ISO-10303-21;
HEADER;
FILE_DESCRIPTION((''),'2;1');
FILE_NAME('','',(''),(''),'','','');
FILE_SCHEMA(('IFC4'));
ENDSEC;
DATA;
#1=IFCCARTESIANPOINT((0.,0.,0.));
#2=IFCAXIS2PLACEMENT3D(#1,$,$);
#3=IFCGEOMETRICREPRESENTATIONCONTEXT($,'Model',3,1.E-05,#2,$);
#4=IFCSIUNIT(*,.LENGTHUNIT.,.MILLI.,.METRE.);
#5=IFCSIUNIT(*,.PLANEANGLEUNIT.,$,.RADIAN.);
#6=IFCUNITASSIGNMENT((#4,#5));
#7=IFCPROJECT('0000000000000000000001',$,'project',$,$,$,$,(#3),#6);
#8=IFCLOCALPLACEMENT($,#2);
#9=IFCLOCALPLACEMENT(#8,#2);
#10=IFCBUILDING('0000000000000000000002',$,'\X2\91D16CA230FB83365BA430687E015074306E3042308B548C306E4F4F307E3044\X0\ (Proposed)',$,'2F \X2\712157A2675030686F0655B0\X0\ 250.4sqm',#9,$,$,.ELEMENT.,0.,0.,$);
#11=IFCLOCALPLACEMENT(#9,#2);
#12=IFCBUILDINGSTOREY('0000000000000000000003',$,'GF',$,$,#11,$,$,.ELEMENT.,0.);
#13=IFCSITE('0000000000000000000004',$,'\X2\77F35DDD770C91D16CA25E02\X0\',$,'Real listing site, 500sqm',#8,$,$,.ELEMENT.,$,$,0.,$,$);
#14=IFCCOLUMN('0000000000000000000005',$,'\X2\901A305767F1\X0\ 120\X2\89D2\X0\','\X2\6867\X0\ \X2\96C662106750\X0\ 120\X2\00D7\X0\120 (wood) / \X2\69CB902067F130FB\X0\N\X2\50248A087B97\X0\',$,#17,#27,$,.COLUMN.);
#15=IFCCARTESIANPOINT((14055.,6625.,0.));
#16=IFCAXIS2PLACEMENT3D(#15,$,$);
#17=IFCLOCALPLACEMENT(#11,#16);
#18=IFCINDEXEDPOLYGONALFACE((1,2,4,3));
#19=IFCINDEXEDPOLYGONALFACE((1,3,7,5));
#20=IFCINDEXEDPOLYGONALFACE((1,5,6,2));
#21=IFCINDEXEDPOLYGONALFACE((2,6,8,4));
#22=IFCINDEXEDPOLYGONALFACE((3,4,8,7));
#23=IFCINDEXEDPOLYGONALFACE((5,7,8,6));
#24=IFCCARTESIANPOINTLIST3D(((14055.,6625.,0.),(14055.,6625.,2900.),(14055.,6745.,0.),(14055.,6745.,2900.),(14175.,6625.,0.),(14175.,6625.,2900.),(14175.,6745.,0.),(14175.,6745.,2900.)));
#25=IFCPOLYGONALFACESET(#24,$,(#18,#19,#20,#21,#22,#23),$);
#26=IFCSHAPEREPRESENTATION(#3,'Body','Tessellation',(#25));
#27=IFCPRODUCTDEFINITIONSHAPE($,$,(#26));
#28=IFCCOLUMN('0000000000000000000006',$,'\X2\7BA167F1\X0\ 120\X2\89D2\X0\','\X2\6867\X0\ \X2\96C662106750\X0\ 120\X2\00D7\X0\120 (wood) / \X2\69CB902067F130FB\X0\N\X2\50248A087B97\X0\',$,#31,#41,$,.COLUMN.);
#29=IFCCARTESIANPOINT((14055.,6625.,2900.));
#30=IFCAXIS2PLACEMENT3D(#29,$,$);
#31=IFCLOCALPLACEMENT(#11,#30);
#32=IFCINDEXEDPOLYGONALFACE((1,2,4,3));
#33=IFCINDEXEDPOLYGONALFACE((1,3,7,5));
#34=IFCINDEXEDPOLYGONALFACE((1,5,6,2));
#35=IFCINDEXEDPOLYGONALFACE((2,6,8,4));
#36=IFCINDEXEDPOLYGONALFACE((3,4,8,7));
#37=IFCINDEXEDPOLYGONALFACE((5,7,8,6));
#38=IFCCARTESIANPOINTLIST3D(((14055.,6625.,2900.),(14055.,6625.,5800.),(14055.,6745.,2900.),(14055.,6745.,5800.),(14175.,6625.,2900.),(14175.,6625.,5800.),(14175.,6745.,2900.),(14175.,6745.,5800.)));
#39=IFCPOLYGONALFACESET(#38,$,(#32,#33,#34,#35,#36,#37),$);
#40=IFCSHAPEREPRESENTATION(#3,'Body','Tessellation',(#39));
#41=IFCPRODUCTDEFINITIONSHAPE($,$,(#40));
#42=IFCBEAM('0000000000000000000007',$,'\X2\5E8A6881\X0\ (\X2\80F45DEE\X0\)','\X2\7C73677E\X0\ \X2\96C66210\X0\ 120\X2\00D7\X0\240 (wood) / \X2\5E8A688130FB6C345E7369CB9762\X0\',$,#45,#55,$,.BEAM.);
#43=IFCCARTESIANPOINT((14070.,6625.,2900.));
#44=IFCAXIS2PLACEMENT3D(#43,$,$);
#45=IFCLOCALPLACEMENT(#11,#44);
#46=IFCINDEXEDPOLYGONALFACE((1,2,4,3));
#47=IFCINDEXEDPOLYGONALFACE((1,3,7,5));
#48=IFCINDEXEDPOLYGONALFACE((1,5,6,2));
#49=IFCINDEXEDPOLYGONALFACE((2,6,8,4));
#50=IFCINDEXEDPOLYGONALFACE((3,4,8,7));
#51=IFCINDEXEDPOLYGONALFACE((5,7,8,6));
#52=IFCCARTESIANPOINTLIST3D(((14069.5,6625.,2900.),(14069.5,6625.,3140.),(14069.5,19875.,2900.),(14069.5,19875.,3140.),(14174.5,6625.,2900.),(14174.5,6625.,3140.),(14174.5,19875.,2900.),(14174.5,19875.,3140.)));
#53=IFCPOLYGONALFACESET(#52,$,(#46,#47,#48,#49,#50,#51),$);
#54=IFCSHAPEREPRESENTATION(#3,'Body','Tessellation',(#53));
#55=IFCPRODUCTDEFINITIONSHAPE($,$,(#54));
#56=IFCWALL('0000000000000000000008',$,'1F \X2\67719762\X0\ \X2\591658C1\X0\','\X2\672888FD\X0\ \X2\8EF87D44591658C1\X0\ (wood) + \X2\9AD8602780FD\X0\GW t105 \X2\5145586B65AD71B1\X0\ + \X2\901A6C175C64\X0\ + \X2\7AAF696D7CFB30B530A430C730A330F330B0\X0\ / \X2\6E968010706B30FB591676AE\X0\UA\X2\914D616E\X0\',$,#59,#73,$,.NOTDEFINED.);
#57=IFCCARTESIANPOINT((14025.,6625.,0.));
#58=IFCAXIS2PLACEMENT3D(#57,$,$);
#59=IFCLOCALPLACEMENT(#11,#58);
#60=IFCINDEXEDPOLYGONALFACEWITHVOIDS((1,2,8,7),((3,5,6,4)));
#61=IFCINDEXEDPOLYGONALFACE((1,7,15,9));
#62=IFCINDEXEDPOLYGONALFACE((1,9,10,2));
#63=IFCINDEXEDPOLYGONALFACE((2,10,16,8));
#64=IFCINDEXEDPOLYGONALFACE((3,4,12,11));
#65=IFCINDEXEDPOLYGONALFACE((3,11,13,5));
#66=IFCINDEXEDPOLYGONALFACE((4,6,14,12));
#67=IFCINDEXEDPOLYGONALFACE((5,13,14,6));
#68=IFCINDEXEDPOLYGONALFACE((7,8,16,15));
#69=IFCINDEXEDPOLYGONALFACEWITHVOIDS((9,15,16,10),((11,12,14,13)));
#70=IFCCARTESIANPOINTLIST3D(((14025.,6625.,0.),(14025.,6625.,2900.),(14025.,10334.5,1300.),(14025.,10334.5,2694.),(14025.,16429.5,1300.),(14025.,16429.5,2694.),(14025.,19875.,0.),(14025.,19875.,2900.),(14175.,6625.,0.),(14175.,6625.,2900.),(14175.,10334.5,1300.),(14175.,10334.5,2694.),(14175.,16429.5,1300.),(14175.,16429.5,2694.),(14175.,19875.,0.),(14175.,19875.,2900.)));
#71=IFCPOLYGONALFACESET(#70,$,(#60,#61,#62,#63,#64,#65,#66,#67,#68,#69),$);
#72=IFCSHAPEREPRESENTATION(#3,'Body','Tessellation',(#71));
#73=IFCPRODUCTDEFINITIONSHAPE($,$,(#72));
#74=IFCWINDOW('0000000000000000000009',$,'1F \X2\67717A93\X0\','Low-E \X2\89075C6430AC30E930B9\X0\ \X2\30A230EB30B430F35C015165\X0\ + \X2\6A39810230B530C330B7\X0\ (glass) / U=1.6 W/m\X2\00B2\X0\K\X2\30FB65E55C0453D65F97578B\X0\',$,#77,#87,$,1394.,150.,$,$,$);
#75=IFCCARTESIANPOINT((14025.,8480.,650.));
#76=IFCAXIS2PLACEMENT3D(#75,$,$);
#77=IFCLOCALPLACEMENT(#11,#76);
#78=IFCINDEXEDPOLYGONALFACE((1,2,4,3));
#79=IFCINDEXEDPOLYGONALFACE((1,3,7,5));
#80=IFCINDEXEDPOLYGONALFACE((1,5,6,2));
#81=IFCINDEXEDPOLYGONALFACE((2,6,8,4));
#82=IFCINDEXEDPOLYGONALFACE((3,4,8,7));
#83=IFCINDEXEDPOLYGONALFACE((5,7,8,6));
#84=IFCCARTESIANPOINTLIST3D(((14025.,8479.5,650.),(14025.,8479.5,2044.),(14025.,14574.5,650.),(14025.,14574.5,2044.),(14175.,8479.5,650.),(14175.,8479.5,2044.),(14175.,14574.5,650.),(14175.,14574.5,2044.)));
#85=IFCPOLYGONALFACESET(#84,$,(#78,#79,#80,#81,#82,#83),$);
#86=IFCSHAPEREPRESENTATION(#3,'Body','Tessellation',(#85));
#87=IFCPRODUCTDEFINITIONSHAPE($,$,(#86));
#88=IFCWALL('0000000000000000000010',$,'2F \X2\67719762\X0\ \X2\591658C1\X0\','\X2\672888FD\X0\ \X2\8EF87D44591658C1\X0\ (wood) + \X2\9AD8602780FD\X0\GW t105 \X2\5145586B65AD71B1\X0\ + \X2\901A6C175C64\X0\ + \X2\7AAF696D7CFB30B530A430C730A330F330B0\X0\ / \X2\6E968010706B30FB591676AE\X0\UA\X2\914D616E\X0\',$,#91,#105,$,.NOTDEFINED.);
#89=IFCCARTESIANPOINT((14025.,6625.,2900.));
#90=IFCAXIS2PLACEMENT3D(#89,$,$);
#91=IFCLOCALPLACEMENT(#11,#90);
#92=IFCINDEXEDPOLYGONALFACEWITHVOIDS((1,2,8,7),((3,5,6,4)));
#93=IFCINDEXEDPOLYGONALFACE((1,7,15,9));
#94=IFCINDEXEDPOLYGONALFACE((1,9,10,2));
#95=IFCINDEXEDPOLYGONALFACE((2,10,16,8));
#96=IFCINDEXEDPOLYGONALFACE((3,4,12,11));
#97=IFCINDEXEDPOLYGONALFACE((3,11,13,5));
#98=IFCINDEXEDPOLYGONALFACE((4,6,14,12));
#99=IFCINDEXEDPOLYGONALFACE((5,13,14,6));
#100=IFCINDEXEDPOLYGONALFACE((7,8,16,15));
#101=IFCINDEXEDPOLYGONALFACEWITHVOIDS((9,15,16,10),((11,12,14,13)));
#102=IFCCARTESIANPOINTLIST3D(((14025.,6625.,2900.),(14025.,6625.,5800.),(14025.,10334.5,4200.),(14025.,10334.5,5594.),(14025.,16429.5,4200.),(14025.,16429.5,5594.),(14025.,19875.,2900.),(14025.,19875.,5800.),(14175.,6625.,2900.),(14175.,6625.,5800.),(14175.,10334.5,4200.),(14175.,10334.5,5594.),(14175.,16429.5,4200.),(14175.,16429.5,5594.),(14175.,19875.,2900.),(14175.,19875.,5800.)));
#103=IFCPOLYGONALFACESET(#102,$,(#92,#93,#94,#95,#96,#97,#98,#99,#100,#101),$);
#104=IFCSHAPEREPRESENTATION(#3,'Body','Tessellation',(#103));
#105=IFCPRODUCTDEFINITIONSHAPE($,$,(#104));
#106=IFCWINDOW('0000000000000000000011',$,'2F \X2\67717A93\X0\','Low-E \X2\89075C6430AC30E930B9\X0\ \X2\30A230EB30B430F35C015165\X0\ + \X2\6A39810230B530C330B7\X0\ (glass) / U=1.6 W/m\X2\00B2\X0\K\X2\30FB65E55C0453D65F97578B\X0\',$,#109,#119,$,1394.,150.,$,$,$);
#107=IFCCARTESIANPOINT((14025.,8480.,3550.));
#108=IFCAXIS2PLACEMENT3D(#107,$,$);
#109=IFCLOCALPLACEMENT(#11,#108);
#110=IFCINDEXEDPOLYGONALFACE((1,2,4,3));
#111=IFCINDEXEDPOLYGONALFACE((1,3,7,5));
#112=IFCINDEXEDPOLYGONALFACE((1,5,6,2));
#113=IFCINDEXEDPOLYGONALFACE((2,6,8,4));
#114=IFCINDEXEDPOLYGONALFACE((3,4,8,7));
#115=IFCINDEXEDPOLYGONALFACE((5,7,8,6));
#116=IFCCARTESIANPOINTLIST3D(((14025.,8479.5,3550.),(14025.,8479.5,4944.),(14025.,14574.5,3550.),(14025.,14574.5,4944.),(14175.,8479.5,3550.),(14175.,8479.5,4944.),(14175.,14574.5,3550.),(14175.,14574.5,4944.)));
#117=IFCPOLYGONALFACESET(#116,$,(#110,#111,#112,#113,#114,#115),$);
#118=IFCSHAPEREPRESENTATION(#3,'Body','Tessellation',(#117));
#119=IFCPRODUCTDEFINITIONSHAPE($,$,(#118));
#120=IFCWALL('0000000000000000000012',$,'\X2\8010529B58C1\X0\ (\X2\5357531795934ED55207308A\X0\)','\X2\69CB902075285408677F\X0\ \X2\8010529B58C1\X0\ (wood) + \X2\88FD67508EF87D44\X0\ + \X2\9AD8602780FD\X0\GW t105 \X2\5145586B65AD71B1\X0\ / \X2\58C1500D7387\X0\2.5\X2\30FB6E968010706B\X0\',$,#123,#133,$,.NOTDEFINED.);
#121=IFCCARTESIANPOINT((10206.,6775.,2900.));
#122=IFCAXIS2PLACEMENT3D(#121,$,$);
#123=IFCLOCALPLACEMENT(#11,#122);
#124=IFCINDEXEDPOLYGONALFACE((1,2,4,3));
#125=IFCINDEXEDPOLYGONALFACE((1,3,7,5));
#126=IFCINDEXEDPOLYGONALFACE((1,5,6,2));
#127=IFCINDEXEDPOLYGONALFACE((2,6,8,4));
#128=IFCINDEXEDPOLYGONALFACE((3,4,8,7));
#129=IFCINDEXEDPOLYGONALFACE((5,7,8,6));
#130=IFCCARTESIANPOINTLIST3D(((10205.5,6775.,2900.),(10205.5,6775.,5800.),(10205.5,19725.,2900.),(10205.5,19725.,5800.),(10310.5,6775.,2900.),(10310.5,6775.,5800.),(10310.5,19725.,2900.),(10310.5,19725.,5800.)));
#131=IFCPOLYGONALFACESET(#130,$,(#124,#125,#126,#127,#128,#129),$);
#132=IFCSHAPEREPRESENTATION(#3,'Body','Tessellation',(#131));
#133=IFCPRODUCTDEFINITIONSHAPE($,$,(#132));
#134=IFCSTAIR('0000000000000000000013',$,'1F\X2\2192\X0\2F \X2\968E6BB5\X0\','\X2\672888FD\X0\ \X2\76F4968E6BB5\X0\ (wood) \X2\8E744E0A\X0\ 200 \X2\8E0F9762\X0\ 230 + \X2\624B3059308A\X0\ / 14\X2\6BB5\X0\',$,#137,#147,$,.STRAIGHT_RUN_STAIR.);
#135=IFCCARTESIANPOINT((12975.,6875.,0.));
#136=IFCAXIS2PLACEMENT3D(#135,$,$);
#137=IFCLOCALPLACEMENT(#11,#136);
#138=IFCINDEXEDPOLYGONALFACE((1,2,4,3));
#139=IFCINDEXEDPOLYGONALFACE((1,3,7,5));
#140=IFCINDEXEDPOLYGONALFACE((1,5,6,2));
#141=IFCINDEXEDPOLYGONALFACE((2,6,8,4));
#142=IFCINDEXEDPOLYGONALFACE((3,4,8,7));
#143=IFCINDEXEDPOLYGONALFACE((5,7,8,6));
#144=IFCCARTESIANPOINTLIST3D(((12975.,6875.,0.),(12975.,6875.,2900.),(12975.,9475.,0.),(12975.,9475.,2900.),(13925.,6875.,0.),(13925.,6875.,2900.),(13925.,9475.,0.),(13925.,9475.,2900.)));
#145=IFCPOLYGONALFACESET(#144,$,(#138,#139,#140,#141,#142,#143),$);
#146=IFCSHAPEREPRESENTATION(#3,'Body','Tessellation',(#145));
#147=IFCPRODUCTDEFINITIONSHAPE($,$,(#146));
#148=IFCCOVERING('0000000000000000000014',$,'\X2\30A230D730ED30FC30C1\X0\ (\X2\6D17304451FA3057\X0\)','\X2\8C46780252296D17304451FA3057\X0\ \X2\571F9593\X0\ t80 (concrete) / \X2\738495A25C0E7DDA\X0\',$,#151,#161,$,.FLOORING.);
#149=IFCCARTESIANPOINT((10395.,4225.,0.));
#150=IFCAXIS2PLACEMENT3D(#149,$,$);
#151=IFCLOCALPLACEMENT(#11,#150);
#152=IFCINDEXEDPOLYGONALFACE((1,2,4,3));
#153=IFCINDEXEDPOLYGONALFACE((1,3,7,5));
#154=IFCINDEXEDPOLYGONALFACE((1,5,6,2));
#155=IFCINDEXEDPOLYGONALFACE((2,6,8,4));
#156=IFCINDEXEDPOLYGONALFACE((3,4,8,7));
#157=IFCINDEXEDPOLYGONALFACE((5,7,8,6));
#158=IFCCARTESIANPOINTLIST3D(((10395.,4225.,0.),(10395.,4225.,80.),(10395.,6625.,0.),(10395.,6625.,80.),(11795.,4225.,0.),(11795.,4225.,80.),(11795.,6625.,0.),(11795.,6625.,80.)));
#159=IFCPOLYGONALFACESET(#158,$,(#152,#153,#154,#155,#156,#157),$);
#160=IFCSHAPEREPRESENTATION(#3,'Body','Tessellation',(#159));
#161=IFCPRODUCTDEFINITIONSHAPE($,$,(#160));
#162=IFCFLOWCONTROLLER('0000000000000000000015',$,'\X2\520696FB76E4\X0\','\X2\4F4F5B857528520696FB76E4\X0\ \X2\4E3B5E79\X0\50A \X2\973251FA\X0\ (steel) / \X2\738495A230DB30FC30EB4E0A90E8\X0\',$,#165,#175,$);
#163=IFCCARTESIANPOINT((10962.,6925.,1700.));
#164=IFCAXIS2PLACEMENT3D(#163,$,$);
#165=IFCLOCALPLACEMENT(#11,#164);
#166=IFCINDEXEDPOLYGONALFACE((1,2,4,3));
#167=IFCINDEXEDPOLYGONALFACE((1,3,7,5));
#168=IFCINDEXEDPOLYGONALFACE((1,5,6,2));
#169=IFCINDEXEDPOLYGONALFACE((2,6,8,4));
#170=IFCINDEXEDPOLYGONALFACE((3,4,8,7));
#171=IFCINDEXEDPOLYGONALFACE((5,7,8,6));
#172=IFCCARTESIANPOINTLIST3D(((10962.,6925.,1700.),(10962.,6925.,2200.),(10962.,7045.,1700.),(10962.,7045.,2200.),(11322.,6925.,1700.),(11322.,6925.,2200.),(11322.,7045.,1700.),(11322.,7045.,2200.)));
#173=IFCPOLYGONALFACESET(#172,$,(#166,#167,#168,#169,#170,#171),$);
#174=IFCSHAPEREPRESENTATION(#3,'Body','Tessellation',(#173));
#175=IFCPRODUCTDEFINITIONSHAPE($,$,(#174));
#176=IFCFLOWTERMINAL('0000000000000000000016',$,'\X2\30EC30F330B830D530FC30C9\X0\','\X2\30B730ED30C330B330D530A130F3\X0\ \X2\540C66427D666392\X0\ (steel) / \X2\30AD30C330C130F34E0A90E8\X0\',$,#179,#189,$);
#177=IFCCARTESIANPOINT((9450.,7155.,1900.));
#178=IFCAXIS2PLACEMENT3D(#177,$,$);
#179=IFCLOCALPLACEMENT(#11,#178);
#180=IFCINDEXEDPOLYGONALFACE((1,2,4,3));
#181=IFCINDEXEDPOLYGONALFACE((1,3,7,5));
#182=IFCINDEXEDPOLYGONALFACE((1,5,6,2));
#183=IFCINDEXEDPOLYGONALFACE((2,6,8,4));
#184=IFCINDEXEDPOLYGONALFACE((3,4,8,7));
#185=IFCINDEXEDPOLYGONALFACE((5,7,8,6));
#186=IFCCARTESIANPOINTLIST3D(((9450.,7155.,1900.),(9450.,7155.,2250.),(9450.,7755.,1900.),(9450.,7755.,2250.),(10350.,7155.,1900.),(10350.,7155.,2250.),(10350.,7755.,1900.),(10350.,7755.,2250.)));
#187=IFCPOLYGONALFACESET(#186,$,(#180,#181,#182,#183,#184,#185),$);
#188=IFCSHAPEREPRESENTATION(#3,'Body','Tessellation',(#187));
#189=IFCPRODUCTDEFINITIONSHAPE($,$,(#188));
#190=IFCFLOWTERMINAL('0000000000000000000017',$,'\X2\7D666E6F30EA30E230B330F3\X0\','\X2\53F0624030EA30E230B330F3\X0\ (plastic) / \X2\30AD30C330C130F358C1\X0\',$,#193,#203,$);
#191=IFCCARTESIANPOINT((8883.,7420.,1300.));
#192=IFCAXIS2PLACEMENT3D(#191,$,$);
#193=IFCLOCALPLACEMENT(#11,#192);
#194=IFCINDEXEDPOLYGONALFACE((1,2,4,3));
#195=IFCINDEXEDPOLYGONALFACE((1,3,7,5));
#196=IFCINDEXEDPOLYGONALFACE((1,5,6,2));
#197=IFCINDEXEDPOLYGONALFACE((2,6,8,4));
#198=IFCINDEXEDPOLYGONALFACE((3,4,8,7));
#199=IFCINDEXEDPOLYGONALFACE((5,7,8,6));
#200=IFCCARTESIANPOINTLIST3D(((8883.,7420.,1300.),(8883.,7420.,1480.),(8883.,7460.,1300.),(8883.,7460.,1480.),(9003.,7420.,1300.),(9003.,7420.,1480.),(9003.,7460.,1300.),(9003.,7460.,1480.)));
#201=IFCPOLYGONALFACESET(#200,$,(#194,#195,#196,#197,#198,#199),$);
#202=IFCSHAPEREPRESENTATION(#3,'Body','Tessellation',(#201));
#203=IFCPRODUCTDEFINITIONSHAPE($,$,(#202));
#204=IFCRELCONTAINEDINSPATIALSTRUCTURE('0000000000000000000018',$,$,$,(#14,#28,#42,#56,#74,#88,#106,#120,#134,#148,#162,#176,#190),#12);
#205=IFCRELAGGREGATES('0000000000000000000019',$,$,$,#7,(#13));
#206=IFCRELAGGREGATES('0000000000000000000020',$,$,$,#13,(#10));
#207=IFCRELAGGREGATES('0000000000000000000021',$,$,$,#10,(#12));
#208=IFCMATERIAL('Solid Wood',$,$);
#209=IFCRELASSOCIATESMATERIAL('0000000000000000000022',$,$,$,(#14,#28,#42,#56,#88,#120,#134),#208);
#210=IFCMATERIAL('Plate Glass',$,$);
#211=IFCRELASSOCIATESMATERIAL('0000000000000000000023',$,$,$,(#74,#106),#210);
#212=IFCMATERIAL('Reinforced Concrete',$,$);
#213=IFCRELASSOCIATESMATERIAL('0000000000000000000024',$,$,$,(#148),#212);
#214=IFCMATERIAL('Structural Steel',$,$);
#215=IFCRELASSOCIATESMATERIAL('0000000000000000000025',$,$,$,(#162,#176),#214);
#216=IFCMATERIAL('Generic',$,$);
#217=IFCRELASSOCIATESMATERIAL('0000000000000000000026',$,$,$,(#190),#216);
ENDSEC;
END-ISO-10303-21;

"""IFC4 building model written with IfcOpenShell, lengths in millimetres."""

from ifc_helpers import new_model, si_unit, frame, frame_2d, origin, place, context, project, spatial, rectangle, extrude, material, element, fill, save


model = new_model("IFC4")

# Units and contexts
model_context = context("Model", 3, precision=1e-05, world=origin())
ifc_project = project(units=[si_unit("LENGTHUNIT", "METRE", prefix="MILLI"), si_unit("PLANEANGLEUNIT", "RADIAN")], contexts=[model_context])

# Site, building, storey
site_placement = place(None, origin())
site = spatial("IfcSite", under=ifc_project, at=site_placement, Name="石川県金沢市", ObjectType="Real listing site, 500sqm", CompositionType="ELEMENT", RefElevation=0.0)
building_placement = place(site_placement, origin())
building = spatial("IfcBuilding", under=site, at=building_placement, Name="金沢・茶室と縁側のある和の住まい (Proposed)", ObjectType="2F 無垢材と漆喰 250.4sqm", CompositionType="ELEMENT", ElevationOfRefHeight=0.0, ElevationOfTerrain=0.0)
storey_placement = place(building_placement, origin())
storey = spatial("IfcBuildingStorey", under=building, at=storey_placement, Name="GF", CompositionType="ELEMENT", Elevation=0.0)

# Columns
ifc_material_1 = material(Name="Solid Wood")
column_1_placement = place(storey_placement, frame((14055.0, 6625.0, 0.0)))
element("IfcColumn", 1, at=column_1_placement, inside=storey, material=ifc_material_1, Name="通し柱 120角", Description="桧 集成材 120×120 (wood) / 構造柱・N値計算", PredefinedType="COLUMN", context=model_context, shape_type="SweptSolid", body=[
    extrude(rectangle(XDim=120.0, YDim=120.0, at=frame_2d((60.0, 60.0))), frame((14055.0, 6625.0, 0.0)), (0.0, 0.0, 1.0), 2900.0),
])
column_2_placement = place(storey_placement, frame((14055.0, 6625.0, 2900.0)))
element("IfcColumn", 2, at=column_2_placement, inside=storey, material=ifc_material_1, Name="管柱 120角", Description="桧 集成材 120×120 (wood) / 構造柱・N値計算", PredefinedType="COLUMN", context=model_context, shape_type="SweptSolid", body=[
    extrude(rectangle(XDim=120.0, YDim=120.0, at=frame_2d((60.0, 60.0))), frame((14055.0, 6625.0, 2900.0)), (0.0, 0.0, 1.0), 2900.0),
])

# Beam
beam_1_placement = place(storey_placement, frame((14070.0, 6625.0, 2900.0)))
element("IfcBeam", 3, at=beam_1_placement, inside=storey, material=ifc_material_1, Name="床梁 (胴差)", Description="米松 集成 120×240 (wood) / 床梁・水平構面", PredefinedType="BEAM", context=model_context, shape_type="SweptSolid", body=[
    extrude(rectangle(XDim=105.0, YDim=13250.0, at=frame_2d((52.0, 6625.0))), frame((14070.0, 6625.0, 2900.0)), (0.0, 0.0, 1.0), 240.0),
])

# Wall, opening, window
wall_1_placement = place(storey_placement, frame((14025.0, 6625.0, 0.0)))
wall_1 = element("IfcWall", 4, at=wall_1_placement, inside=storey, material=ifc_material_1, Name="1F 東面 外壁", Description="木製 軸組外壁 (wood) + 高性能GW t105 充填断熱 + 通気層 + 窯業系サイディング / 準耐火・外皮UA配慮", PredefinedType="NOTDEFINED", context=model_context, shape_type="SweptSolid", body=[
    extrude(rectangle(XDim=150.0, YDim=13250.0, at=frame_2d((75.0, 6625.0))), frame((14025.0, 6625.0, 0.0)), (0.0, 0.0, 1.0), 2900.0),
])
opening_1_placement = place(storey_placement, frame((14025.0, 8480.0, 650.0)))
opening_1 = element("IfcOpeningElement", 5, at=opening_1_placement, cuts=wall_1, PredefinedType="NOTDEFINED", context=model_context, shape_type="SweptSolid", body=[
    extrude(rectangle(XDim=150.0, YDim=6095.0, at=frame_2d((75.0, 3047.0))), frame((14025.0, 8480.0, 650.0)), (0.0, 0.0, 1.0), 1394.0),
])
ifc_material_2 = material(Name="Plate Glass")
window_1_placement = place(storey_placement, frame((14025.0, 8480.0, 650.0)))
window_1 = element("IfcWindow", 6, at=window_1_placement, inside=storey, material=ifc_material_2, Name="1F 東窓", Description="Low-E 複層ガラス アルゴン封入 + 樹脂サッシ (glass) / U=1.6 W/m²K・日射取得型", OverallHeight=1394.0, OverallWidth=150.0, context=model_context, shape_type="SweptSolid", body=[
    extrude(rectangle(XDim=150.0, YDim=6095.0, at=frame_2d((75.0, 3047.0))), frame((14025.0, 8480.0, 650.0)), (0.0, 0.0, 1.0), 1394.0),
])
fill(opening_1, window_1)

# Wall, opening, window
wall_2_placement = place(storey_placement, frame((14025.0, 6625.0, 2900.0)))
wall_2 = element("IfcWall", 7, at=wall_2_placement, inside=storey, material=ifc_material_1, Name="2F 東面 外壁", Description="木製 軸組外壁 (wood) + 高性能GW t105 充填断熱 + 通気層 + 窯業系サイディング / 準耐火・外皮UA配慮", PredefinedType="NOTDEFINED", context=model_context, shape_type="SweptSolid", body=[
    extrude(rectangle(XDim=150.0, YDim=13250.0, at=frame_2d((75.0, 6625.0))), frame((14025.0, 6625.0, 2900.0)), (0.0, 0.0, 1.0), 2900.0),
])
opening_2_placement = place(storey_placement, frame((14025.0, 8480.0, 3550.0)))
opening_2 = element("IfcOpeningElement", 8, at=opening_2_placement, cuts=wall_2, PredefinedType="NOTDEFINED", context=model_context, shape_type="SweptSolid", body=[
    extrude(rectangle(XDim=150.0, YDim=6095.0, at=frame_2d((75.0, 3047.0))), frame((14025.0, 8480.0, 3550.0)), (0.0, 0.0, 1.0), 1394.0),
])
window_2_placement = place(storey_placement, frame((14025.0, 8480.0, 3550.0)))
window_2 = element("IfcWindow", 9, at=window_2_placement, inside=storey, material=ifc_material_2, Name="2F 東窓", Description="Low-E 複層ガラス アルゴン封入 + 樹脂サッシ (glass) / U=1.6 W/m²K・日射取得型", OverallHeight=1394.0, OverallWidth=150.0, context=model_context, shape_type="SweptSolid", body=[
    extrude(rectangle(XDim=150.0, YDim=6095.0, at=frame_2d((75.0, 3047.0))), frame((14025.0, 8480.0, 3550.0)), (0.0, 0.0, 1.0), 1394.0),
])
fill(opening_2, window_2)

# Wall
wall_3_placement = place(storey_placement, frame((10206.0, 6775.0, 2900.0)))
element("IfcWall", 10, at=wall_3_placement, inside=storey, material=ifc_material_1, Name="耐力壁 (南北間仕切り)", Description="構造用合板 耐力壁 (wood) + 製材軸組 + 高性能GW t105 充填断熱 / 壁倍率2.5・準耐火", PredefinedType="NOTDEFINED", context=model_context, shape_type="SweptSolid", body=[
    extrude(rectangle(XDim=105.0, YDim=12950.0, at=frame_2d((52.0, 6475.0))), frame((10206.0, 6775.0, 2900.0)), (0.0, 0.0, 1.0), 2900.0),
])

# Stair
stair_placement = place(storey_placement, frame((12975.0, 6875.0, 0.0)))
element("IfcStair", 11, at=stair_placement, inside=storey, material=ifc_material_1, Name="1F→2F 階段", Description="木製 直階段 (wood) 蹴上 200 踏面 230 + 手すり / 14段", PredefinedType="STRAIGHT_RUN_STAIR", context=model_context, shape_type="SweptSolid", body=[
    extrude(rectangle(XDim=950.0, YDim=2600.0, at=frame_2d((475.0, 1300.0))), frame((12975.0, 6875.0, 0.0)), (0.0, 0.0, 1.0), 2900.0),
])

# Covering
ifc_material_3 = material(Name="Reinforced Concrete")
covering_placement = place(storey_placement, frame((10395.0, 4225.0, 0.0)))
element("IfcCovering", 12, at=covering_placement, inside=storey, material=ifc_material_3, Name="アプローチ (洗い出し)", Description="豆砂利洗い出し 土間 t80 (concrete) / 玄関導線", PredefinedType="FLOORING", context=model_context, shape_type="SweptSolid", body=[
    extrude(rectangle(XDim=1400.0, YDim=2400.0, at=frame_2d((700.0, 1200.0))), frame((10395.0, 4225.0, 0.0)), (0.0, 0.0, 1.0), 80.0),
])

# Flow controller
ifc_material_4 = material(Name="Structural Steel")
flow_controller_placement = place(storey_placement, frame((10962.0, 6925.0, 1700.0)))
element("IfcFlowController", 13, at=flow_controller_placement, inside=storey, material=ifc_material_4, Name="分電盤", Description="住宅用分電盤 主幹50A 露出 (steel) / 玄関ホール上部", context=model_context, shape_type="SweptSolid", body=[
    extrude(rectangle(XDim=360.0, YDim=120.0, at=frame_2d((180.0, 60.0))), frame((10962.0, 6925.0, 1700.0)), (0.0, 0.0, 1.0), 500.0),
])

# Flow terminals
flow_terminal_1_placement = place(storey_placement, frame((9450.0, 7155.0, 1900.0)))
element("IfcFlowTerminal", 14, at=flow_terminal_1_placement, inside=storey, material=ifc_material_4, Name="レンジフード", Description="シロッコファン 同時給排 (steel) / キッチン上部", context=model_context, shape_type="SweptSolid", body=[
    extrude(rectangle(XDim=900.0, YDim=600.0, at=frame_2d((450.0, 300.0))), frame((9450.0, 7155.0, 1900.0)), (0.0, 0.0, 1.0), 350.0),
])
ifc_material_5 = material(Name="Generic")
flow_terminal_2_placement = place(storey_placement, frame((8883.0, 7420.0, 1300.0)))
element("IfcFlowTerminal", 15, at=flow_terminal_2_placement, inside=storey, material=ifc_material_5, Name="給湯リモコン", Description="台所リモコン (plastic) / キッチン壁", context=model_context, shape_type="SweptSolid", body=[
    extrude(rectangle(XDim=120.0, YDim=40.0, at=frame_2d((60.0, 20.0))), frame((8883.0, 7420.0, 1300.0)), (0.0, 0.0, 1.0), 180.0),
])

save(model, "model.ifc")
